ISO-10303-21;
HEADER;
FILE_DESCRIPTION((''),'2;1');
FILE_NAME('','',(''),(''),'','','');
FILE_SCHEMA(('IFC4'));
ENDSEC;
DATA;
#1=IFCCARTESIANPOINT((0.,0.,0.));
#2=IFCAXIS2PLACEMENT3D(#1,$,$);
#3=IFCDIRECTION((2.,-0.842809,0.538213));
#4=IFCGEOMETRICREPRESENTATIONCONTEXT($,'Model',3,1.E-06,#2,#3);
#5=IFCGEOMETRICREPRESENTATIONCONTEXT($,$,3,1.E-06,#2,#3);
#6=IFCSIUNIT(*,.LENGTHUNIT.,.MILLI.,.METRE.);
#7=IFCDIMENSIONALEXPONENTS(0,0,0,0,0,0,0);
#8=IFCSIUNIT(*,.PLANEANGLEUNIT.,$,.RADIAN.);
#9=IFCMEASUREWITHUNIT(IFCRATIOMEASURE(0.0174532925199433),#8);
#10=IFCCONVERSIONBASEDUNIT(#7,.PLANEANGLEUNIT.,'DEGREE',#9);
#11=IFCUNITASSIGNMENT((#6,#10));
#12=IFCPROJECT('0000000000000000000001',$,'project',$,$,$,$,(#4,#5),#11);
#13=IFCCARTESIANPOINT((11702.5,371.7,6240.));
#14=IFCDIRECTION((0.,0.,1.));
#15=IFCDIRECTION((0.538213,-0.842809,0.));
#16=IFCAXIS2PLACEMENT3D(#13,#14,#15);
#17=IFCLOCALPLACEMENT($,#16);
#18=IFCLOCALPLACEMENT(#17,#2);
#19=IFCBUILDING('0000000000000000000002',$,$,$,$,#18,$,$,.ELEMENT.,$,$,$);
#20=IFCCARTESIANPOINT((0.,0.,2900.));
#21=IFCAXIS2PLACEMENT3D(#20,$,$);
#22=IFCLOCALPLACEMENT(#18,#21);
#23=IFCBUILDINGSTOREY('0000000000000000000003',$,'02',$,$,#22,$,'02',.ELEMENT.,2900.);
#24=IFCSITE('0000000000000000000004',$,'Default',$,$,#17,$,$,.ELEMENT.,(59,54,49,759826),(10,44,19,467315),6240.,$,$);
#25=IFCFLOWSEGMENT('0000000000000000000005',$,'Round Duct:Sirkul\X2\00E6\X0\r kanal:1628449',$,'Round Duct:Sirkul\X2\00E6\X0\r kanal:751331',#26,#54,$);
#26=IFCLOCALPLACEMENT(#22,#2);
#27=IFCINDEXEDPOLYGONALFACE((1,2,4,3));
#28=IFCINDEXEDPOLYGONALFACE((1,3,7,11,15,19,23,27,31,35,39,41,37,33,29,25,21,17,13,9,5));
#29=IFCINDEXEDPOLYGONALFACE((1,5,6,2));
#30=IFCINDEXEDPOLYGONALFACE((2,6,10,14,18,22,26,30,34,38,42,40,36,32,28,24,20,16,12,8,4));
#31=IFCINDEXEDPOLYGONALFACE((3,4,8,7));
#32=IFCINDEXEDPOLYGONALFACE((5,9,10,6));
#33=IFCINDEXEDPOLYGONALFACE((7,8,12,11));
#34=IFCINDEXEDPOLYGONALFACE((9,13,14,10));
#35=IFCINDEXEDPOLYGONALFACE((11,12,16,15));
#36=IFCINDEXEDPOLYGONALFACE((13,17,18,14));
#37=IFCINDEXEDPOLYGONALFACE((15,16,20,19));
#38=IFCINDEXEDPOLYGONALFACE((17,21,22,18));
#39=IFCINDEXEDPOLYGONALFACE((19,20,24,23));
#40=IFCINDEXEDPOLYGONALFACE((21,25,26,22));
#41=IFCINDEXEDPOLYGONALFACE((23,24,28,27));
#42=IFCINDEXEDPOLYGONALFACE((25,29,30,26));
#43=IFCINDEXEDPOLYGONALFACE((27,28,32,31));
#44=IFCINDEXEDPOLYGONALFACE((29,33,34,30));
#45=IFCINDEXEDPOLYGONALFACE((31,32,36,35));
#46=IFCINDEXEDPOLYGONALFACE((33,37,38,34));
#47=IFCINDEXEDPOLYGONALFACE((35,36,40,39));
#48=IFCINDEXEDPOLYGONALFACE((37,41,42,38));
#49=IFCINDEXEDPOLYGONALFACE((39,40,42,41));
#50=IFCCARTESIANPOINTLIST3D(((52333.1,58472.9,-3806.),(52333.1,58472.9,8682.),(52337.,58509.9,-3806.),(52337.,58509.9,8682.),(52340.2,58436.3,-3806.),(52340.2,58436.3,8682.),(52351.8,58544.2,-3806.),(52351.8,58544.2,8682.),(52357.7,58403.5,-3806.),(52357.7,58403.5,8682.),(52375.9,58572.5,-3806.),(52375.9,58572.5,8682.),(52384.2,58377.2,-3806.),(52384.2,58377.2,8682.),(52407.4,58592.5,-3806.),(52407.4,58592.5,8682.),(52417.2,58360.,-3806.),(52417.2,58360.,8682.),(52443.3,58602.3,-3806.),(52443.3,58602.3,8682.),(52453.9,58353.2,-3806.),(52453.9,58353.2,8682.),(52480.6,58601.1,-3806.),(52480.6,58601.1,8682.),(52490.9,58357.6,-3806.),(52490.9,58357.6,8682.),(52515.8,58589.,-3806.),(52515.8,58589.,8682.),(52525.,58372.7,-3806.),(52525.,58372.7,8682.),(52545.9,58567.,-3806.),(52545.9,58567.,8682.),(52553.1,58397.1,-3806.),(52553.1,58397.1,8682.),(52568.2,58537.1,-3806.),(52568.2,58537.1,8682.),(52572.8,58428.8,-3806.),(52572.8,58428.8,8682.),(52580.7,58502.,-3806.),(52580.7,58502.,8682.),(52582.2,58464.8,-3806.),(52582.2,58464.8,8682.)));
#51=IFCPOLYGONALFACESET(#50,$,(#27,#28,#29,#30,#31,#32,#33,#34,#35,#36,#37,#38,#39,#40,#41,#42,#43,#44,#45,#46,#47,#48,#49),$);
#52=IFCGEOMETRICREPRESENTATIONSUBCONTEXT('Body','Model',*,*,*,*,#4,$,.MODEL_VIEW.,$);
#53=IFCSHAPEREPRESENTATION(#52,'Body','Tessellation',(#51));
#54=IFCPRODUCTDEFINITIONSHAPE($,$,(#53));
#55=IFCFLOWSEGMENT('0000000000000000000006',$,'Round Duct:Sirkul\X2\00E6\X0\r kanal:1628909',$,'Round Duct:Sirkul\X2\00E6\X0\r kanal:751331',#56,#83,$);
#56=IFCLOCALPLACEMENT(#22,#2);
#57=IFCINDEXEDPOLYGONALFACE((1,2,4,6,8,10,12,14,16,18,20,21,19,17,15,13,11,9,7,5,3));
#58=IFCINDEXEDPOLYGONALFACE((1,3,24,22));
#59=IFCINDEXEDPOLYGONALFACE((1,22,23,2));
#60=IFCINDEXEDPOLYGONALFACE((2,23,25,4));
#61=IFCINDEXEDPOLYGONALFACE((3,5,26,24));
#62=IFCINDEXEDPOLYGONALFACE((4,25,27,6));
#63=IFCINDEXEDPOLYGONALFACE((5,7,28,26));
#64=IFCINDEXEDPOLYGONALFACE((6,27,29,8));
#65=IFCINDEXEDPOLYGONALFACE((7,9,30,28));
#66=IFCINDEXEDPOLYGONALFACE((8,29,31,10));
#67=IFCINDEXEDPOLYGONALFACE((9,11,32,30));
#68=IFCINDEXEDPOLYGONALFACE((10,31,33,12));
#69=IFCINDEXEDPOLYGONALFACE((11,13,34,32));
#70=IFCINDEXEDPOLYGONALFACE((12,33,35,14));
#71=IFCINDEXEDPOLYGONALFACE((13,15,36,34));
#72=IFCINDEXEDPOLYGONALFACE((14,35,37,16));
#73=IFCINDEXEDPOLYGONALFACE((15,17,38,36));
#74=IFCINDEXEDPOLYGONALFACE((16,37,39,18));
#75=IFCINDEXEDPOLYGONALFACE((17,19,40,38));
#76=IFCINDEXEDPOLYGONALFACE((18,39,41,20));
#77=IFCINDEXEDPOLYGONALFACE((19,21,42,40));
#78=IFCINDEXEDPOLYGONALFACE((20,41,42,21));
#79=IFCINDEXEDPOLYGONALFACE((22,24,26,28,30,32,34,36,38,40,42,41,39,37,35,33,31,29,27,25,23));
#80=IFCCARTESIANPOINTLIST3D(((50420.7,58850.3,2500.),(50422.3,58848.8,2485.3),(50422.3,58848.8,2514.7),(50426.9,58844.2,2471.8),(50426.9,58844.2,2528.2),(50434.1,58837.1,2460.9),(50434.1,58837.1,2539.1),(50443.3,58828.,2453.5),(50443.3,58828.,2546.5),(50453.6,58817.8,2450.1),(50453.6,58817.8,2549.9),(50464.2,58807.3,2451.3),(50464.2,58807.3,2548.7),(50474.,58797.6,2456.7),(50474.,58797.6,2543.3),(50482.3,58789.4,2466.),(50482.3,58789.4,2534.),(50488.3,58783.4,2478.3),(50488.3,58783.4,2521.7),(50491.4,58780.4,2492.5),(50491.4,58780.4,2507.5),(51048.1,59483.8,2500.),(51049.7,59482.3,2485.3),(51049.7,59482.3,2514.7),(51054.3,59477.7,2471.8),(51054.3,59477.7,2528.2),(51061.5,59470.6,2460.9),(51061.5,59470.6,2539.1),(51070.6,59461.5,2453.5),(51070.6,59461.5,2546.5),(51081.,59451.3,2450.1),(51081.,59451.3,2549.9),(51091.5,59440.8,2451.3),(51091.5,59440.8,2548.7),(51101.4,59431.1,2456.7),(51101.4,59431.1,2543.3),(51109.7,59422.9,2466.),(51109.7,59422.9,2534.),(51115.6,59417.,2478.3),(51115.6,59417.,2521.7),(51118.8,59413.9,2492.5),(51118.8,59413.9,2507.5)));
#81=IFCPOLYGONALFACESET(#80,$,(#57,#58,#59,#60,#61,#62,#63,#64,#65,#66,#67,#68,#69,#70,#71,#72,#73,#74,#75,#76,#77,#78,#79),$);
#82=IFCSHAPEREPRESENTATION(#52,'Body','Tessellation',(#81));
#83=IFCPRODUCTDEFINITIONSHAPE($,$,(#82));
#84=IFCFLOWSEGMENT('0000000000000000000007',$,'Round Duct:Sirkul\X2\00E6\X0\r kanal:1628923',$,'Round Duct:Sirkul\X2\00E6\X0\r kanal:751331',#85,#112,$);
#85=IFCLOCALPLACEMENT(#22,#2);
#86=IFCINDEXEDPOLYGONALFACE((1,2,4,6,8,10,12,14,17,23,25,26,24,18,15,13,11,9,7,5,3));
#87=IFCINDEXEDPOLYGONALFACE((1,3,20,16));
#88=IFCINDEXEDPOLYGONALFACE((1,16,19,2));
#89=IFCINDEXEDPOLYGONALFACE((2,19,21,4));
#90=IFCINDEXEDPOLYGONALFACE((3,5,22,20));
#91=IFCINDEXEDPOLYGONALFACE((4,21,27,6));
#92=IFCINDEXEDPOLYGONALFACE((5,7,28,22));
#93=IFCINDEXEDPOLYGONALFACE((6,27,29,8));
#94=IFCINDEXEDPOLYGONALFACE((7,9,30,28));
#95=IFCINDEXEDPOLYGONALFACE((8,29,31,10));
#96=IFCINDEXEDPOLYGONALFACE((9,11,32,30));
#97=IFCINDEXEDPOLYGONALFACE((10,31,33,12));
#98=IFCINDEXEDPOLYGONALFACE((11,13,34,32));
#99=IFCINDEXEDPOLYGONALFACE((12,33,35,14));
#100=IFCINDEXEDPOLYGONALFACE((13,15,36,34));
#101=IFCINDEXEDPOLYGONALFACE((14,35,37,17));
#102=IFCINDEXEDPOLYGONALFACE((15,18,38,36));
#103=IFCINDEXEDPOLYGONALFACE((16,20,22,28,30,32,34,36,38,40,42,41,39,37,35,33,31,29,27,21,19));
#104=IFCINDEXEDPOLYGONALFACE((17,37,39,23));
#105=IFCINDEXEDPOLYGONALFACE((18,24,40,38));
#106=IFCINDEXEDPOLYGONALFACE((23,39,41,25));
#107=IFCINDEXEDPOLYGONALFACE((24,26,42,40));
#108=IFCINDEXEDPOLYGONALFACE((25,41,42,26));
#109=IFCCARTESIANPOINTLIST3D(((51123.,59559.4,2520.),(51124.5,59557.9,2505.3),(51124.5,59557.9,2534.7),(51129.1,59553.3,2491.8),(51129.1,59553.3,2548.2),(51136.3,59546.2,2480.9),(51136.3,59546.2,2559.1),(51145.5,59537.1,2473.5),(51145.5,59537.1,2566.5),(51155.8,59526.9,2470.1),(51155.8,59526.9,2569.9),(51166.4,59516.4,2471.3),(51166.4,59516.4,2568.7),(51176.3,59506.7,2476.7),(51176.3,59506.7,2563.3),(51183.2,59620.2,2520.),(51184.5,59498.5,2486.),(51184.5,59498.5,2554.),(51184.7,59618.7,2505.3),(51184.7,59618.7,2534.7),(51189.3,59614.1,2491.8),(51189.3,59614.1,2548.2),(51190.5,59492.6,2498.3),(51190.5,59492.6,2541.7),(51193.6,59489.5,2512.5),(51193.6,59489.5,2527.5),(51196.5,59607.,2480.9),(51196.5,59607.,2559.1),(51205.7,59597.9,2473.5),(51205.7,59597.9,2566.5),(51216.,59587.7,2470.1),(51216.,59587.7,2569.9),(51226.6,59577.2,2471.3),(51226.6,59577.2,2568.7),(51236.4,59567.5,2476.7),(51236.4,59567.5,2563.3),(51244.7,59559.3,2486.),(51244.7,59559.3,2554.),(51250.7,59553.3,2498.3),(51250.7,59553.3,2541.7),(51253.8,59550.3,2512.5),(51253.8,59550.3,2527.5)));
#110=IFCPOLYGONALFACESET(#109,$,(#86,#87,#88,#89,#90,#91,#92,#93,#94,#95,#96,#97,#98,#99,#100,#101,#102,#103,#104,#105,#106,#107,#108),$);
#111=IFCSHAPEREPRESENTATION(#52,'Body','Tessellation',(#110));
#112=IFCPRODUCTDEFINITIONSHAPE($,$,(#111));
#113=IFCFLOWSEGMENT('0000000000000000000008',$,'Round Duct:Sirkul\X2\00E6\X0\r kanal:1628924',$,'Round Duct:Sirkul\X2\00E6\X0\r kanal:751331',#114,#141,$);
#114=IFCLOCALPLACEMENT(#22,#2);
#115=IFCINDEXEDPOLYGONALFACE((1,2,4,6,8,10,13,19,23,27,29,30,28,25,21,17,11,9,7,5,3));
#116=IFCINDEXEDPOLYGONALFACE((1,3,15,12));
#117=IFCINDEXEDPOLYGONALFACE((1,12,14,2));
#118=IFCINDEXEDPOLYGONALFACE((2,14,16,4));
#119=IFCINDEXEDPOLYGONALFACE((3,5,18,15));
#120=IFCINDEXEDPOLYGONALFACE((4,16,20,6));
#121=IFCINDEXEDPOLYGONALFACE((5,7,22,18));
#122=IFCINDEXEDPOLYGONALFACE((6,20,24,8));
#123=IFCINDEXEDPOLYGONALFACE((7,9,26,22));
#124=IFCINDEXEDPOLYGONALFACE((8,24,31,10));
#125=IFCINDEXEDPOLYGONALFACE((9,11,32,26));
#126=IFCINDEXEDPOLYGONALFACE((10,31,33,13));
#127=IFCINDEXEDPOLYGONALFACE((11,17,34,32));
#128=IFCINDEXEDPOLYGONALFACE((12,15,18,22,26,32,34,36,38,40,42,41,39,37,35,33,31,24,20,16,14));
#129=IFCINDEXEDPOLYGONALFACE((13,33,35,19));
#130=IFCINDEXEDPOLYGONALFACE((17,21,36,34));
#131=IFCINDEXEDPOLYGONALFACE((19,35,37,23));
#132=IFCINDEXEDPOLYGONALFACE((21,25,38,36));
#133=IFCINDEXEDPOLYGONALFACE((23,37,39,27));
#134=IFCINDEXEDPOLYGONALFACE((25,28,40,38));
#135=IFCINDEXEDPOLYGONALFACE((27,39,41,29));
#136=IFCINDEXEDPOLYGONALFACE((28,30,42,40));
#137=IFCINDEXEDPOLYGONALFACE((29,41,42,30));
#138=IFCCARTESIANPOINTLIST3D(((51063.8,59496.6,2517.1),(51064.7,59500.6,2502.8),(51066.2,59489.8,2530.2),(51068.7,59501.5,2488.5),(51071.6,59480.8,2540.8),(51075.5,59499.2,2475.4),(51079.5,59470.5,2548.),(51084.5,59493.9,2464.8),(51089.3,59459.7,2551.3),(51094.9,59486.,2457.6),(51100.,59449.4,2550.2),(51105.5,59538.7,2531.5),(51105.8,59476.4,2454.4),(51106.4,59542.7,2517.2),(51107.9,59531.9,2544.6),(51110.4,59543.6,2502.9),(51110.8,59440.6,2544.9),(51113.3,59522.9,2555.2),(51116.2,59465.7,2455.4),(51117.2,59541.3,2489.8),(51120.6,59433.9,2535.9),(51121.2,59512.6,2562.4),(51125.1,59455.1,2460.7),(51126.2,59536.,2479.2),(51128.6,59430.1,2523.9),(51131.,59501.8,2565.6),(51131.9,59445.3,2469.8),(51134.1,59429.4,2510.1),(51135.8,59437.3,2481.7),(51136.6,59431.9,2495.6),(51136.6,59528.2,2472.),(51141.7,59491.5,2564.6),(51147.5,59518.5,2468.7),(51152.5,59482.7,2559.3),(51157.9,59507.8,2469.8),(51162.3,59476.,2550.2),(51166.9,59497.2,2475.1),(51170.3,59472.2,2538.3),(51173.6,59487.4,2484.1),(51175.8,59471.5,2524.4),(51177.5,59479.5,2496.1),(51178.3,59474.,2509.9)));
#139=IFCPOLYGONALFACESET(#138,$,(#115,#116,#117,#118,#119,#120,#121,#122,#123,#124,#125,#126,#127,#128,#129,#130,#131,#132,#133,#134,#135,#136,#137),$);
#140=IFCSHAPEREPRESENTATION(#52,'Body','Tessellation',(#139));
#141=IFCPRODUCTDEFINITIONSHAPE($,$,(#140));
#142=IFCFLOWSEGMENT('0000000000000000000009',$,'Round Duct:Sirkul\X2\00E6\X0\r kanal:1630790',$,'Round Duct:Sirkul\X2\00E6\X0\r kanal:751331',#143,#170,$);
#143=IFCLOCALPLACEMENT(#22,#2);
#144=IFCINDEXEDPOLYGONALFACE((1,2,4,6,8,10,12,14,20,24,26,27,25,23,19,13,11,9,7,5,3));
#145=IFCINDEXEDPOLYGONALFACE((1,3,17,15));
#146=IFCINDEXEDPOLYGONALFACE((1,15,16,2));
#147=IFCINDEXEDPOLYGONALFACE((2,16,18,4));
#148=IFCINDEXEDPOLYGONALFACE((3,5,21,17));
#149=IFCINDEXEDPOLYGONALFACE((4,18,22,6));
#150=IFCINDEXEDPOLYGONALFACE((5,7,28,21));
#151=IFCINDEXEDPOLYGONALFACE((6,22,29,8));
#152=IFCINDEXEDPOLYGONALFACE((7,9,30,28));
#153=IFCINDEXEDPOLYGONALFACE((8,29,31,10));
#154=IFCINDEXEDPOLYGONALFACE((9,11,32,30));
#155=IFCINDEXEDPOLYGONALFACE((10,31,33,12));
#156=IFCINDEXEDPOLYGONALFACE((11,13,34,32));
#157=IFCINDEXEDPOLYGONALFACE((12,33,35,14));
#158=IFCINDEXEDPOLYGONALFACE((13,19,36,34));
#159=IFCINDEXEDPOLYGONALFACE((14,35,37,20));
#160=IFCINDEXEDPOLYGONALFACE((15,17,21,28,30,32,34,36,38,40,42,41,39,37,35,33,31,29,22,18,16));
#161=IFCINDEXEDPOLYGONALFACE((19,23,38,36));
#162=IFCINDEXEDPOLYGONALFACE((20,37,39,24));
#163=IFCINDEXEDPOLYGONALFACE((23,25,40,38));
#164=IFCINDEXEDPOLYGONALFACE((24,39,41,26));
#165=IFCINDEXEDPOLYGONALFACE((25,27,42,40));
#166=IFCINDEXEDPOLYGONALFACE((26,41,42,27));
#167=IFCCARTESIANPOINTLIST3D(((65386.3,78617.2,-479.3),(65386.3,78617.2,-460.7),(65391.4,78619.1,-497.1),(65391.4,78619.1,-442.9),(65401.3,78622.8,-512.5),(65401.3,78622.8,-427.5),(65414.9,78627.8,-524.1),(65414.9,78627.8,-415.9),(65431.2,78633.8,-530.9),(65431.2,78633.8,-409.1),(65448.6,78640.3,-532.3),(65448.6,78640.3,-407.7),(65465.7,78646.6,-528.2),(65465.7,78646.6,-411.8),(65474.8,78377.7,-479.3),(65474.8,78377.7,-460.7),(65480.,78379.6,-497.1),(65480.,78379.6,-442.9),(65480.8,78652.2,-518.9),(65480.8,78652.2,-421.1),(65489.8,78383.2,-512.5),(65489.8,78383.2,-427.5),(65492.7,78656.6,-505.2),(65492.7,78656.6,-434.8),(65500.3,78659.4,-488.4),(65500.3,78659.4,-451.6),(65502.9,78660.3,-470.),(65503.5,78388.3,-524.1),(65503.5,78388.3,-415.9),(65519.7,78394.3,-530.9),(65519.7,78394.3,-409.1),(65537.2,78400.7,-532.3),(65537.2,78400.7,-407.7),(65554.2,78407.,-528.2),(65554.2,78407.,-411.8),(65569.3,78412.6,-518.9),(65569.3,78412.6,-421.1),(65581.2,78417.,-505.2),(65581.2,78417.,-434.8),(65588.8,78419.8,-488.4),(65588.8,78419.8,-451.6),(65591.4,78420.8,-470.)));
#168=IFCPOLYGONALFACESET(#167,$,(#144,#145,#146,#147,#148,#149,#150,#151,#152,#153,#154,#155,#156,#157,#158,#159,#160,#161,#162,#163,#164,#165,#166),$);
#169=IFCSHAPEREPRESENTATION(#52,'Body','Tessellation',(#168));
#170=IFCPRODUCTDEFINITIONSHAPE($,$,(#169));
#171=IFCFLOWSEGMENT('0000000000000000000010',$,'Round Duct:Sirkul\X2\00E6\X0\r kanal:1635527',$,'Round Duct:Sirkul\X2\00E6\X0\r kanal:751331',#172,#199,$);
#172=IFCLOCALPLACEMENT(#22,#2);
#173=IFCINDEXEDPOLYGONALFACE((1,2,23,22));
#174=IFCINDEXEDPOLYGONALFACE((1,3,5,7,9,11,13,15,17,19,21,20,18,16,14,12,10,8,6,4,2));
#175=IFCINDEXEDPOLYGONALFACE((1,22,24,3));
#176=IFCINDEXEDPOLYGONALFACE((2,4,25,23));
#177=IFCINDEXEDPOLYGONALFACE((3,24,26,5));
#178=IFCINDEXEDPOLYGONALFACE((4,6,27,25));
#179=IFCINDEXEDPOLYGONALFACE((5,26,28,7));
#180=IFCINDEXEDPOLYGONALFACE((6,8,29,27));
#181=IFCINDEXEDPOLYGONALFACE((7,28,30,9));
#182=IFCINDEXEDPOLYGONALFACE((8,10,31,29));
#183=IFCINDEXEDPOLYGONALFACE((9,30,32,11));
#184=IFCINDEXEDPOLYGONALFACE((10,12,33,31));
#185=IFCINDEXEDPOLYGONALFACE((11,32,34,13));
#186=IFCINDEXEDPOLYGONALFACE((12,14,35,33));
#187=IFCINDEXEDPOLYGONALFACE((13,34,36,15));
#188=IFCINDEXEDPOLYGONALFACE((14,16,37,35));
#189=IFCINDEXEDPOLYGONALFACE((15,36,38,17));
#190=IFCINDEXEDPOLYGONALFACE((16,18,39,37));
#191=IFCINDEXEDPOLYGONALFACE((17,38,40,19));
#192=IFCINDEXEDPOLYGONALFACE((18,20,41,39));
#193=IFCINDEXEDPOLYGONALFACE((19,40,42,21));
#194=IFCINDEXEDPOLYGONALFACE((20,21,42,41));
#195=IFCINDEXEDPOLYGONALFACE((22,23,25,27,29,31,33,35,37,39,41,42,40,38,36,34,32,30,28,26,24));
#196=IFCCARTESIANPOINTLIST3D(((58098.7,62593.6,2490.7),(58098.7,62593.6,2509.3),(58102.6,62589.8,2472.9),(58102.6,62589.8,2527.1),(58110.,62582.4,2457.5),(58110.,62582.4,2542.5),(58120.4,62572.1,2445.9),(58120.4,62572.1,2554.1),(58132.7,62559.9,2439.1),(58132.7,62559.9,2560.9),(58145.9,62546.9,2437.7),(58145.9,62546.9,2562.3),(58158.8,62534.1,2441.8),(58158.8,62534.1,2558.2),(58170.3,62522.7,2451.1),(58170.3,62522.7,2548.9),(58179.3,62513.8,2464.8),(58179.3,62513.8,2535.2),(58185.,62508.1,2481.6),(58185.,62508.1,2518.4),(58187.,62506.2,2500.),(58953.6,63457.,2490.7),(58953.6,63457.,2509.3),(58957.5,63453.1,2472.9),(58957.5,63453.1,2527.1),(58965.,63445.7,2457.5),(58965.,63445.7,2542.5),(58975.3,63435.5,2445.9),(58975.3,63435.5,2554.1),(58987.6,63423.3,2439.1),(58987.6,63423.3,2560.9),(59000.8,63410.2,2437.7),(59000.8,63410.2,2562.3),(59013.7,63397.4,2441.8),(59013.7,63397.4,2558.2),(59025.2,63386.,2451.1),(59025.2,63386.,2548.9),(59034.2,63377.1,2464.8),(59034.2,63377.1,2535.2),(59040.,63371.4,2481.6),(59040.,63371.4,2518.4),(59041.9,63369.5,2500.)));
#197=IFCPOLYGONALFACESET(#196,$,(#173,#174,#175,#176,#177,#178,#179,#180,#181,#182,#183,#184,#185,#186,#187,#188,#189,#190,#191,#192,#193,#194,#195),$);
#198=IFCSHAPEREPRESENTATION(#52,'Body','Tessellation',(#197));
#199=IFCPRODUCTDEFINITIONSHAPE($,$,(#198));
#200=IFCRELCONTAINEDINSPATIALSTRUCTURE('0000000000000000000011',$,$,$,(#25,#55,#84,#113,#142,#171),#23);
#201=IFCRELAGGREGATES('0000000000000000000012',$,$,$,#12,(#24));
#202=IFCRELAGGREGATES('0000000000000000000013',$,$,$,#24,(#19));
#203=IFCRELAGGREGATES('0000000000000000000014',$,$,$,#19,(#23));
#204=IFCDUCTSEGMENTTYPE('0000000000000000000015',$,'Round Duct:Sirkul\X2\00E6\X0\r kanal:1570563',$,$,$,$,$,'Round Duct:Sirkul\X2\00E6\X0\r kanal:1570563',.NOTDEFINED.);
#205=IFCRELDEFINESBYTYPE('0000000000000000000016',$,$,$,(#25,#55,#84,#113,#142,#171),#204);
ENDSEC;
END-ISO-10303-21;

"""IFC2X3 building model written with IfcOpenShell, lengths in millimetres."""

from ifc_helpers import new_model, entity, si_unit, converted_unit, direction, frame, frame_2d, origin, origin_2d_with_axis, place, context, subcontext, project, spatial, circle, extrude, type_object, element, save


model = new_model("IFC2X3")

# Units and contexts
model_context = context("Model", 3, precision=1e-06, world=origin(), true_north=direction((2.0, -0.842809, 0.538213)))
context_of_model = context(None, 3, precision=1e-06, world=origin(), true_north=direction((2.0, -0.842809, 0.538213)))
body_context = subcontext(model_context, "Body", "Model", "MODEL_VIEW")
ifc_project = project(units=[si_unit("LENGTHUNIT", "METRE", prefix="MILLI"), converted_unit("PLANEANGLEUNIT", "DEGREE", entity("IfcRatioMeasure", 0.0174532925199433), si_unit("PLANEANGLEUNIT", "RADIAN"), dimensions=[0, 0, 0, 0, 0, 0, 0])], contexts=[model_context, context_of_model])

# Site, building, storey
site_placement = place(None, frame((11702.5, 371.7, 6240.0), z_axis=(0.0, 0.0, 1.0), x_axis=(0.538213, -0.842809, 0.0)))
site = spatial("IfcSite", under=ifc_project, at=site_placement, Name="Default", CompositionType="ELEMENT", RefLatitude=(59, 54, 49, 759826), RefLongitude=(10, 44, 19, 467315), RefElevation=6240.0)
building_placement = place(site_placement, origin())
building = spatial("IfcBuilding", under=site, at=building_placement, CompositionType="ELEMENT")
storey_placement = place(building_placement, frame((0.0, 0.0, 2900.0)))
storey = spatial("IfcBuildingStorey", under=building, at=storey_placement, Name="02", LongName="02", CompositionType="ELEMENT", Elevation=2900.0)

# Flow segments
duct_segment_type = type_object("IfcDuctSegmentType", Name="Round Duct:Sirkulær kanal:1570563", ElementType="Round Duct:Sirkulær kanal:1570563", PredefinedType="NOTDEFINED")
flow_segment_1_placement = place(storey_placement, origin())
element("IfcFlowSegment", 1, at=flow_segment_1_placement, inside=storey, type_object=duct_segment_type, Name="Round Duct:Sirkulær kanal:1628449", ObjectType="Round Duct:Sirkulær kanal:751331", context=body_context, shape_type="SweptSolid", body=[
    extrude(circle(Radius=125.0, at=frame_2d((0.0, 0.0), x_axis=(1.0, 0.0))), frame((52457.9, 58478.2, -3806.0), z_axis=(0.0, 0.0, 1.0), x_axis=(0.703643, 0.710554, 0.0)), (0.0, 0.0, 1.0), 12488.0),
])
flow_segment_2_placement = place(storey_placement, origin())
element("IfcFlowSegment", 2, at=flow_segment_2_placement, inside=storey, type_object=duct_segment_type, Name="Round Duct:Sirkulær kanal:1628909", ObjectType="Round Duct:Sirkulær kanal:751331", context=body_context, shape_type="SweptSolid", body=[
    extrude(circle(Radius=50.0, at=frame_2d((0.0, 0.0), x_axis=(1.0, 0.0))), frame((50456.3, 58815.1, 2500.0), z_axis=(0.703643, 0.710554, 0.0), x_axis=(-0.710554, 0.703643, 0.0)), (0.0, 0.0, 1.0), 891.6),
])
flow_segment_3_placement = place(storey_placement, origin())
element("IfcFlowSegment", 3, at=flow_segment_3_placement, inside=storey, type_object=duct_segment_type, Name="Round Duct:Sirkulær kanal:1628923", ObjectType="Round Duct:Sirkulær kanal:751331", context=body_context, shape_type="SweptSolid", body=[
    extrude(circle(Radius=50.0, at=origin_2d_with_axis()), frame((51158.5, 59524.3, 2520.0), z_axis=(0.703643, 0.710554, 0.0), x_axis=(-0.710554, 0.703643, 0.0)), (0.0, 0.0, 1.0), 85.5),
])
flow_segment_4_placement = place(storey_placement, origin())
element("IfcFlowSegment", 4, at=flow_segment_4_placement, inside=storey, type_object=duct_segment_type, Name="Round Duct:Sirkulær kanal:1628924", ObjectType="Round Duct:Sirkulær kanal:751331", context=body_context, shape_type="SweptSolid", body=[
    extrude(circle(Radius=50.0, at=frame_2d((0.0, 0.0), x_axis=(1.0, 0.0))), frame((51100.2, 59465.4, 2502.8), z_axis=(0.683835, 0.690552, 0.2356), x_axis=(-0.710554, 0.703643, 0.0)), (0.0, 0.0, 1.0), 61.0),
])
flow_segment_5_placement = place(storey_placement, origin())
element("IfcFlowSegment", 5, at=flow_segment_5_placement, inside=storey, type_object=duct_segment_type, Name="Round Duct:Sirkulær kanal:1630790", ObjectType="Round Duct:Sirkulær kanal:751331", context=body_context, shape_type="SweptSolid", body=[
    extrude(circle(Radius=62.5, at=origin_2d_with_axis()), frame((65532.8, 78399.1, -470.0), z_axis=(-0.346633, 0.938001, 0.0), x_axis=(0.938001, 0.346633, 0.0)), (0.0, 0.0, 1.0), 255.4),
])
flow_segment_6_placement = place(storey_placement, origin())
element("IfcFlowSegment", 6, at=flow_segment_6_placement, inside=storey, type_object=duct_segment_type, Name="Round Duct:Sirkulær kanal:1635527", ObjectType="Round Duct:Sirkulær kanal:751331", context=body_context, shape_type="SweptSolid", body=[
    extrude(circle(Radius=62.5, at=origin_2d_with_axis()), frame((58142.6, 62550.1, 2500.0), z_axis=(0.703643, 0.710554, 0.0), x_axis=(0.710554, -0.703643, 0.0)), (0.0, 0.0, 1.0), 1215.0),
])

save(model, "model.ifc")
